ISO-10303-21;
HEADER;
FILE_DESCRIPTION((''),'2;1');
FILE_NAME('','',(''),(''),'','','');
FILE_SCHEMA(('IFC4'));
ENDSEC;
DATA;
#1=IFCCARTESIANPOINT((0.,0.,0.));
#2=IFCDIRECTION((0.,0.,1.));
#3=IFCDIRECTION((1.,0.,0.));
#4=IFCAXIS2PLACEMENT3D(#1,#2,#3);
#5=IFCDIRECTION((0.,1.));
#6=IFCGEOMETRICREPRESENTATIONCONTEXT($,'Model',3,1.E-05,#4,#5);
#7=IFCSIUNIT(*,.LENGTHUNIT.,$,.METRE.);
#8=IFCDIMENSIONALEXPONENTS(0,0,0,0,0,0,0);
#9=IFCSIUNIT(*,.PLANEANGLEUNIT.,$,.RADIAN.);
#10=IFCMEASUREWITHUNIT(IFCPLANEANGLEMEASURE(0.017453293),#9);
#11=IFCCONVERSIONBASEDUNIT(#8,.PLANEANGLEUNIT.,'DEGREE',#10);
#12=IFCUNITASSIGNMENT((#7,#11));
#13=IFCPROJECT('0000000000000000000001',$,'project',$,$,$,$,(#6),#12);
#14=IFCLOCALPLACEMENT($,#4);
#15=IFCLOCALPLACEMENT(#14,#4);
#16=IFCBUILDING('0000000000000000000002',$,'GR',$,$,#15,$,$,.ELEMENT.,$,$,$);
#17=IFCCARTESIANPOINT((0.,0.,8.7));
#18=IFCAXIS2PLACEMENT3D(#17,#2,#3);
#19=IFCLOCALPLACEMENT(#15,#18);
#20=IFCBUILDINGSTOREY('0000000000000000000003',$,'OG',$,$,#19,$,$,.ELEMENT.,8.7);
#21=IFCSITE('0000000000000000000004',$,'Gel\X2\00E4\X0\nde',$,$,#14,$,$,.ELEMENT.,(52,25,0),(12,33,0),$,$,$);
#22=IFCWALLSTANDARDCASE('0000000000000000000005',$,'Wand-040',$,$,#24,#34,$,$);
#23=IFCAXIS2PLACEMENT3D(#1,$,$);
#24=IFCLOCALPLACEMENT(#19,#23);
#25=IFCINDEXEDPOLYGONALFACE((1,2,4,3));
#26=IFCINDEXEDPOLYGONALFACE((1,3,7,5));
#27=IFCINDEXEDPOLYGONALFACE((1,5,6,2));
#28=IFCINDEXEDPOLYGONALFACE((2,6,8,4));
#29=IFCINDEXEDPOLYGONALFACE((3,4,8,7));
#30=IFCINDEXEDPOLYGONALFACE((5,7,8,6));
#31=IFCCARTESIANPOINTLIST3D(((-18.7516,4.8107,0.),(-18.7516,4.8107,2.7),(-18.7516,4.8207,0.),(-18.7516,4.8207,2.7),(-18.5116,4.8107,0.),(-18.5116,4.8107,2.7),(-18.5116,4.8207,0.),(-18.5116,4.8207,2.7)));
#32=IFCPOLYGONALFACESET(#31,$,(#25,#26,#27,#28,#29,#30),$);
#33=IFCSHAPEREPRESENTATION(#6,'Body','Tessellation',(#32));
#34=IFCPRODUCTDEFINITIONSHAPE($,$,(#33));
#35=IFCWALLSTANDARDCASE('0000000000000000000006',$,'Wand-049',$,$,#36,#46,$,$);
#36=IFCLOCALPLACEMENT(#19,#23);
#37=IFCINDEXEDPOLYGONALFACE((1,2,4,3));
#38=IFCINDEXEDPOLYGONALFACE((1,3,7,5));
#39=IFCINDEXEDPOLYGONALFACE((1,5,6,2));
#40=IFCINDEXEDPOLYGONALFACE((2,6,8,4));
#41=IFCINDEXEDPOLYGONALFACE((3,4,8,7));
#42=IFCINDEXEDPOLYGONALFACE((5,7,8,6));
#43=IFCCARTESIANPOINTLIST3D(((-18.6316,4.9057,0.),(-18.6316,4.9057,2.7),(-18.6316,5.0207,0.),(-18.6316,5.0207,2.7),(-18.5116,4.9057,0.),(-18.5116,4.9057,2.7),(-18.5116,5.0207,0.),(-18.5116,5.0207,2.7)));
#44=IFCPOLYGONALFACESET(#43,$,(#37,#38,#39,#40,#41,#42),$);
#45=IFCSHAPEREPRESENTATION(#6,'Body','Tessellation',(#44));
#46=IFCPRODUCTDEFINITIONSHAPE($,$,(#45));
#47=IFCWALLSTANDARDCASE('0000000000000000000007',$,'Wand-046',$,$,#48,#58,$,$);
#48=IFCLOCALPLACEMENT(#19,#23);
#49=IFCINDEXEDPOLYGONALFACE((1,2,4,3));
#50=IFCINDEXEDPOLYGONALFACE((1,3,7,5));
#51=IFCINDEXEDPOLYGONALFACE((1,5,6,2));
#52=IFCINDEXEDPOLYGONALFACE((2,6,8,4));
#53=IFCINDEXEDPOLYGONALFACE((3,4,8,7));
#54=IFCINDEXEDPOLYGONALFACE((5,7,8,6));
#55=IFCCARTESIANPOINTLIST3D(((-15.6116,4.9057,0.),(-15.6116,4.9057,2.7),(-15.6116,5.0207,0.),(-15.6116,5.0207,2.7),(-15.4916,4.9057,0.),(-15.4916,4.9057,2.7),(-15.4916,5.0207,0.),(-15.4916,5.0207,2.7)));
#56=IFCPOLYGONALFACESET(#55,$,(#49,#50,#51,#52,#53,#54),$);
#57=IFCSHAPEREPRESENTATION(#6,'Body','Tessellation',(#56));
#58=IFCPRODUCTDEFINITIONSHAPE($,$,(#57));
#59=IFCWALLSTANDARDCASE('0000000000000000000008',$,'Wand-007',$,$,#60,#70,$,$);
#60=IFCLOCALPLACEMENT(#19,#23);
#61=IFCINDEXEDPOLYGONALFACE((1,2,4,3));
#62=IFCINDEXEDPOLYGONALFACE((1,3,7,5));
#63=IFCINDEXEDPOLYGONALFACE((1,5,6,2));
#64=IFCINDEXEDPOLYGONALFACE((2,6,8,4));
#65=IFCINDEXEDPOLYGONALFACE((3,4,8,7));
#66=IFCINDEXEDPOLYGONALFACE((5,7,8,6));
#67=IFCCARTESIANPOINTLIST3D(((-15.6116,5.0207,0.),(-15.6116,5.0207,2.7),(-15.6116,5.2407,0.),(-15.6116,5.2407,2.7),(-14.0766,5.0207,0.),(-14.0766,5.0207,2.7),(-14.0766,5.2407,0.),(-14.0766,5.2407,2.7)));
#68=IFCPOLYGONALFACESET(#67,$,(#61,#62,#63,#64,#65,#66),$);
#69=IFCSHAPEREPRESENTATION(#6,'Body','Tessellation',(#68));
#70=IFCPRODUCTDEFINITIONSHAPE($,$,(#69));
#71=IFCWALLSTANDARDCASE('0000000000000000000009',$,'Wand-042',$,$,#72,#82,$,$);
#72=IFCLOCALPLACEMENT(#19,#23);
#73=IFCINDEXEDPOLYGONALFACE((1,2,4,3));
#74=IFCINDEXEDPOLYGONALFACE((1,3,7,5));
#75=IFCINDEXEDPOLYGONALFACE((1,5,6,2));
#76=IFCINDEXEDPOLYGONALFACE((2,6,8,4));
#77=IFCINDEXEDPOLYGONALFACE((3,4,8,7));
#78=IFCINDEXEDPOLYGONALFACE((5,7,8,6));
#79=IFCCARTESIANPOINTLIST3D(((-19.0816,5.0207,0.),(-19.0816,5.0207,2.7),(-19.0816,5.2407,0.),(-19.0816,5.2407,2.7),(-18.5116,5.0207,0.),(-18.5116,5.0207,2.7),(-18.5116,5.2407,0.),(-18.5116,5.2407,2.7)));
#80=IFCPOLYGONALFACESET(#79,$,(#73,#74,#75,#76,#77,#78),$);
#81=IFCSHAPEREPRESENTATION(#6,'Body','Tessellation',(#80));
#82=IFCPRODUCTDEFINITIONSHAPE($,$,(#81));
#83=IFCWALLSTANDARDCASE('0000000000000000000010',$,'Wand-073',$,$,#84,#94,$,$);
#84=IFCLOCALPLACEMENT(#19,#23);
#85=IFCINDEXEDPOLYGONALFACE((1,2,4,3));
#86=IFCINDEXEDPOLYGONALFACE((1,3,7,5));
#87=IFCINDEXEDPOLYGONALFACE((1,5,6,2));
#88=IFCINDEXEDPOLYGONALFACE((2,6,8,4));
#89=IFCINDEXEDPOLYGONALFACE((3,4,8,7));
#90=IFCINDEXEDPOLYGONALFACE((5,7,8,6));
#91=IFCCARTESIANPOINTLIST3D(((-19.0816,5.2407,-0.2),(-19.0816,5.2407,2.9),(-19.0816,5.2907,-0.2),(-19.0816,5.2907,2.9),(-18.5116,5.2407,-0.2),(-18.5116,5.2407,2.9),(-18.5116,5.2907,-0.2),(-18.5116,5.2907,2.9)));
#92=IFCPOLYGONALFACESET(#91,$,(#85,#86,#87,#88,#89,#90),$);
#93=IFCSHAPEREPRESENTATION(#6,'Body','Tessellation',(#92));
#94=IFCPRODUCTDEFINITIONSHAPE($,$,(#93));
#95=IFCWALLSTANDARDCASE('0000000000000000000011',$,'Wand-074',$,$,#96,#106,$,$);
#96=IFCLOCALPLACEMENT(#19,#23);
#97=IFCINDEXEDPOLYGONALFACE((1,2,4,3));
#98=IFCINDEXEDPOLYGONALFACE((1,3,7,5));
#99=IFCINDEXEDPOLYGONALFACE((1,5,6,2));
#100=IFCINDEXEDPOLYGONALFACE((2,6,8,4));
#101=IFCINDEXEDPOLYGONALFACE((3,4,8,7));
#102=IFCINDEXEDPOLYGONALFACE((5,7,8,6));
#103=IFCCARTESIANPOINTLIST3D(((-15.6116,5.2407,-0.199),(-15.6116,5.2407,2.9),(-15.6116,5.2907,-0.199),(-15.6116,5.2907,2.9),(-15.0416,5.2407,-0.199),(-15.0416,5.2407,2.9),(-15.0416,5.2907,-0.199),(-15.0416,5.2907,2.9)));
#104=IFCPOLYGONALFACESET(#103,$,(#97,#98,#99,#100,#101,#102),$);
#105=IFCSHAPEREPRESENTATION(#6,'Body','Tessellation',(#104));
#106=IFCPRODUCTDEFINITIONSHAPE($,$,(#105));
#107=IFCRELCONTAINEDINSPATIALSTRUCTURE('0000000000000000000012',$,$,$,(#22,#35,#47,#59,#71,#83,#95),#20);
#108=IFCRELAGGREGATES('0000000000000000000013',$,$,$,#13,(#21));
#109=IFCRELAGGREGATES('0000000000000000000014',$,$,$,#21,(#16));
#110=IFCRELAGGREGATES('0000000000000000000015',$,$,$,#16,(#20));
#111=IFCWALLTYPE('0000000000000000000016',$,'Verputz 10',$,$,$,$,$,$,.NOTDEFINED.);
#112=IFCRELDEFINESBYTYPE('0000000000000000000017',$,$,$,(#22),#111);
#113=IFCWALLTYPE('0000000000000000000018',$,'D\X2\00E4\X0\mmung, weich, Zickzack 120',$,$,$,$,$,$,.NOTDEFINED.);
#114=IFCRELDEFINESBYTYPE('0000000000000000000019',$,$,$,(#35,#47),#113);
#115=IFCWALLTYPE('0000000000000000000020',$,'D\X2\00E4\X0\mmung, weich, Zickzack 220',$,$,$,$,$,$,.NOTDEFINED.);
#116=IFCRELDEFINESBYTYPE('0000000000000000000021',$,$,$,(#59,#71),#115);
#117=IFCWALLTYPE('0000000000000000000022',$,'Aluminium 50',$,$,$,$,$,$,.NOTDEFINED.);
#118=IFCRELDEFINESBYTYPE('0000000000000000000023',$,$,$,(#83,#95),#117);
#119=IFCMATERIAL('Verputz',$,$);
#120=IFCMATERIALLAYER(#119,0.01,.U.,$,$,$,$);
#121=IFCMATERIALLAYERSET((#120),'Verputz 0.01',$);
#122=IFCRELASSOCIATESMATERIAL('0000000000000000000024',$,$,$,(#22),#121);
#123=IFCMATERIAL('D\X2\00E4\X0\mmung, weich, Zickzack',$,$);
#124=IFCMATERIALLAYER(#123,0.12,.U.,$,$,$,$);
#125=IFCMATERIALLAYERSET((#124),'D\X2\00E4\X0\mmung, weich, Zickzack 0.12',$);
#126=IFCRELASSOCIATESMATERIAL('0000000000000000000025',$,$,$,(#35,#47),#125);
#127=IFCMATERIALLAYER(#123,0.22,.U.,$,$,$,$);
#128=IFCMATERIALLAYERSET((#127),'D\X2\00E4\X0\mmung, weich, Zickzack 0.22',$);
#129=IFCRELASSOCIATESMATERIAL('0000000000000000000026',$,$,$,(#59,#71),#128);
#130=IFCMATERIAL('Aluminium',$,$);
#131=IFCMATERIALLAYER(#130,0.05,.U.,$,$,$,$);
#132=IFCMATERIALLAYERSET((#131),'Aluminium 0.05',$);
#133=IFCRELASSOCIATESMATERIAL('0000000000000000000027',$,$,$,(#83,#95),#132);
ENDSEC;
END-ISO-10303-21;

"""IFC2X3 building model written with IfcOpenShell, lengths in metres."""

from ifc_helpers import new_model, entity, si_unit, converted_unit, direction, frame, origin_with_axes, place, context, project, spatial, polyline, outline, extrude, material, layer, layer_set, layer_usage, type_object, element, save


model = new_model("IFC2X3")

# Units and contexts
model_context = context("Model", 3, precision=1e-05, world=origin_with_axes(), true_north=direction((0.0, 1.0)))
ifc_project = project(units=[si_unit("LENGTHUNIT", "METRE"), converted_unit("PLANEANGLEUNIT", "DEGREE", entity("IfcPlaneAngleMeasure", 0.017453293), si_unit("PLANEANGLEUNIT", "RADIAN"), dimensions=[0, 0, 0, 0, 0, 0, 0])], contexts=[model_context])

# Site, building, storey
site_placement = place(None, origin_with_axes())
site = spatial("IfcSite", under=ifc_project, at=site_placement, Name="Gelände", CompositionType="ELEMENT", RefLatitude=(52, 25, 0), RefLongitude=(12, 33, 0))
building_placement = place(site_placement, origin_with_axes())
building = spatial("IfcBuilding", under=site, at=building_placement, Name="GR", CompositionType="ELEMENT")
storey_placement = place(building_placement, frame((0.0, 0.0, 8.7), z_axis=(0.0, 0.0, 1.0), x_axis=(1.0, 0.0, 0.0)))
storey = spatial("IfcBuildingStorey", under=building, at=storey_placement, Name="OG", CompositionType="ELEMENT", Elevation=8.7)

# Walls
ifc_material_1 = material(Name="Verputz")
ifc_layer_1 = layer(ifc_material_1, 0.01, ventilated="UNKNOWN")
ifc_layer_set_1 = layer_set([ifc_layer_1], Name="Verputz 0.01")
wall_type_1 = type_object("IfcWallType", Name="Verputz 10", PredefinedType="NOTDEFINED")
ifc_layer_usage_1 = layer_usage(ifc_layer_set_1, "AXIS2", "NEGATIVE", 0.0)
wall_1_placement = place(storey_placement, frame((-18.7516, 4.8207, 0.0), z_axis=(0.0, 0.0, 1.0), x_axis=(1.0, 0.0, 0.0)))
element("IfcWallStandardCase", 1, at=wall_1_placement, inside=storey, type_object=wall_type_1, material=ifc_layer_usage_1, Name="Wand-040", context=model_context, shape_type="SweptSolid", body=[
    extrude(outline(polyline([(0.0, -0.01), (0.24, -0.01), (0.24, 0.0), (0.0, 0.0), (0.0, -0.01)])), origin_with_axes(), (0.0, 0.0, 1.0), 2.7),
])
ifc_material_2 = material(Name="Dämmung, weich, Zickzack")
ifc_layer_2 = layer(ifc_material_2, 0.12, ventilated="UNKNOWN")
ifc_layer_set_2 = layer_set([ifc_layer_2], Name="Dämmung, weich, Zickzack 0.12")
ifc_layer_usage_2 = layer_usage(ifc_layer_set_2, "AXIS2", "POSITIVE", 0.0)
wall_type_2 = type_object("IfcWallType", Name="Dämmung, weich, Zickzack 120", PredefinedType="NOTDEFINED")
wall_2_placement = place(storey_placement, frame((-18.5116, 4.9057, 0.0), z_axis=(0.0, 0.0, 1.0), x_axis=(0.0, 1.0, 0.0)))
element("IfcWallStandardCase", 2, at=wall_2_placement, inside=storey, type_object=wall_type_2, material=ifc_layer_usage_2, Name="Wand-049", context=model_context, shape_type="SweptSolid", body=[
    extrude(outline(polyline([(0.0, 0.0), (0.115, 0.0), (0.115, 0.12), (0.0, 0.12), (0.0, 0.0)])), origin_with_axes(), (0.0, 0.0, 1.0), 2.7),
])
ifc_layer_usage_3 = layer_usage(ifc_layer_set_2, "AXIS2", "POSITIVE", 0.0)
wall_3_placement = place(storey_placement, frame((-15.6116, 5.0207, 0.0), z_axis=(0.0, 0.0, 1.0), x_axis=(0.0, -1.0, 0.0)))
element("IfcWallStandardCase", 3, at=wall_3_placement, inside=storey, type_object=wall_type_2, material=ifc_layer_usage_3, Name="Wand-046", context=model_context, shape_type="SweptSolid", body=[
    extrude(outline(polyline([(0.0, 0.0), (0.115, 0.0), (0.115, 0.12), (0.0, 0.12), (0.0, 0.0)])), origin_with_axes(), (0.0, 0.0, 1.0), 2.7),
])
ifc_layer_3 = layer(ifc_material_2, 0.22, ventilated="UNKNOWN")
ifc_layer_set_3 = layer_set([ifc_layer_3], Name="Dämmung, weich, Zickzack 0.22")
ifc_layer_usage_4 = layer_usage(ifc_layer_set_3, "AXIS2", "POSITIVE", 0.0)
wall_type_3 = type_object("IfcWallType", Name="Dämmung, weich, Zickzack 220", PredefinedType="NOTDEFINED")
wall_4_placement = place(storey_placement, frame((-15.6116, 5.0207, 0.0), z_axis=(0.0, 0.0, 1.0), x_axis=(1.0, 0.0, 0.0)))
element("IfcWallStandardCase", 4, at=wall_4_placement, inside=storey, type_object=wall_type_3, material=ifc_layer_usage_4, Name="Wand-007", context=model_context, shape_type="SweptSolid", body=[
    extrude(outline(polyline([(0.0, 0.0), (1.535, 0.0), (1.535, 0.22), (0.0, 0.22), (0.0, 0.0)])), origin_with_axes(), (0.0, 0.0, 1.0), 2.7),
])
ifc_layer_usage_5 = layer_usage(ifc_layer_set_3, "AXIS2", "POSITIVE", 0.0)
wall_5_placement = place(storey_placement, frame((-19.0816, 5.0207, 0.0), z_axis=(0.0, 0.0, 1.0), x_axis=(1.0, 0.0, 0.0)))
element("IfcWallStandardCase", 5, at=wall_5_placement, inside=storey, type_object=wall_type_3, material=ifc_layer_usage_5, Name="Wand-042", context=model_context, shape_type="SweptSolid", body=[
    extrude(outline(polyline([(0.0, 0.0), (0.57, 0.0), (0.57, 0.22), (0.0, 0.22), (0.0, 0.0)])), origin_with_axes(), (0.0, 0.0, 1.0), 2.7),
])
ifc_material_3 = material(Name="Aluminium")
ifc_layer_4 = layer(ifc_material_3, 0.05, ventilated="UNKNOWN")
ifc_layer_set_4 = layer_set([ifc_layer_4], Name="Aluminium 0.05")
ifc_layer_usage_6 = layer_usage(ifc_layer_set_4, "AXIS2", "POSITIVE", 0.0)
wall_type_4 = type_object("IfcWallType", Name="Aluminium 50", PredefinedType="NOTDEFINED")
wall_6_placement = place(storey_placement, frame((-19.0816, 5.2407, -0.2), z_axis=(0.0, 0.0, 1.0), x_axis=(1.0, 0.0, 0.0)))
element("IfcWallStandardCase", 6, at=wall_6_placement, inside=storey, type_object=wall_type_4, material=ifc_layer_usage_6, Name="Wand-073", context=model_context, shape_type="SweptSolid", body=[
    extrude(outline(polyline([(0.0, 0.0), (0.57, 0.0), (0.57, 0.05), (0.0, 0.05), (0.0, 0.0)])), origin_with_axes(), (0.0, 0.0, 1.0), 3.1),
])
ifc_layer_usage_7 = layer_usage(ifc_layer_set_4, "AXIS2", "POSITIVE", 0.0)
wall_7_placement = place(storey_placement, frame((-15.6116, 5.2407, -0.199), z_axis=(0.0, 0.0, 1.0), x_axis=(1.0, 0.0, 0.0)))
element("IfcWallStandardCase", 7, at=wall_7_placement, inside=storey, type_object=wall_type_4, material=ifc_layer_usage_7, Name="Wand-074", context=model_context, shape_type="SweptSolid", body=[
    extrude(outline(polyline([(0.0, 0.0), (0.57, 0.0), (0.57, 0.05), (0.0, 0.05), (0.0, 0.0)])), origin_with_axes(), (0.0, 0.0, 1.0), 3.099),
])

save(model, "model.ifc")
